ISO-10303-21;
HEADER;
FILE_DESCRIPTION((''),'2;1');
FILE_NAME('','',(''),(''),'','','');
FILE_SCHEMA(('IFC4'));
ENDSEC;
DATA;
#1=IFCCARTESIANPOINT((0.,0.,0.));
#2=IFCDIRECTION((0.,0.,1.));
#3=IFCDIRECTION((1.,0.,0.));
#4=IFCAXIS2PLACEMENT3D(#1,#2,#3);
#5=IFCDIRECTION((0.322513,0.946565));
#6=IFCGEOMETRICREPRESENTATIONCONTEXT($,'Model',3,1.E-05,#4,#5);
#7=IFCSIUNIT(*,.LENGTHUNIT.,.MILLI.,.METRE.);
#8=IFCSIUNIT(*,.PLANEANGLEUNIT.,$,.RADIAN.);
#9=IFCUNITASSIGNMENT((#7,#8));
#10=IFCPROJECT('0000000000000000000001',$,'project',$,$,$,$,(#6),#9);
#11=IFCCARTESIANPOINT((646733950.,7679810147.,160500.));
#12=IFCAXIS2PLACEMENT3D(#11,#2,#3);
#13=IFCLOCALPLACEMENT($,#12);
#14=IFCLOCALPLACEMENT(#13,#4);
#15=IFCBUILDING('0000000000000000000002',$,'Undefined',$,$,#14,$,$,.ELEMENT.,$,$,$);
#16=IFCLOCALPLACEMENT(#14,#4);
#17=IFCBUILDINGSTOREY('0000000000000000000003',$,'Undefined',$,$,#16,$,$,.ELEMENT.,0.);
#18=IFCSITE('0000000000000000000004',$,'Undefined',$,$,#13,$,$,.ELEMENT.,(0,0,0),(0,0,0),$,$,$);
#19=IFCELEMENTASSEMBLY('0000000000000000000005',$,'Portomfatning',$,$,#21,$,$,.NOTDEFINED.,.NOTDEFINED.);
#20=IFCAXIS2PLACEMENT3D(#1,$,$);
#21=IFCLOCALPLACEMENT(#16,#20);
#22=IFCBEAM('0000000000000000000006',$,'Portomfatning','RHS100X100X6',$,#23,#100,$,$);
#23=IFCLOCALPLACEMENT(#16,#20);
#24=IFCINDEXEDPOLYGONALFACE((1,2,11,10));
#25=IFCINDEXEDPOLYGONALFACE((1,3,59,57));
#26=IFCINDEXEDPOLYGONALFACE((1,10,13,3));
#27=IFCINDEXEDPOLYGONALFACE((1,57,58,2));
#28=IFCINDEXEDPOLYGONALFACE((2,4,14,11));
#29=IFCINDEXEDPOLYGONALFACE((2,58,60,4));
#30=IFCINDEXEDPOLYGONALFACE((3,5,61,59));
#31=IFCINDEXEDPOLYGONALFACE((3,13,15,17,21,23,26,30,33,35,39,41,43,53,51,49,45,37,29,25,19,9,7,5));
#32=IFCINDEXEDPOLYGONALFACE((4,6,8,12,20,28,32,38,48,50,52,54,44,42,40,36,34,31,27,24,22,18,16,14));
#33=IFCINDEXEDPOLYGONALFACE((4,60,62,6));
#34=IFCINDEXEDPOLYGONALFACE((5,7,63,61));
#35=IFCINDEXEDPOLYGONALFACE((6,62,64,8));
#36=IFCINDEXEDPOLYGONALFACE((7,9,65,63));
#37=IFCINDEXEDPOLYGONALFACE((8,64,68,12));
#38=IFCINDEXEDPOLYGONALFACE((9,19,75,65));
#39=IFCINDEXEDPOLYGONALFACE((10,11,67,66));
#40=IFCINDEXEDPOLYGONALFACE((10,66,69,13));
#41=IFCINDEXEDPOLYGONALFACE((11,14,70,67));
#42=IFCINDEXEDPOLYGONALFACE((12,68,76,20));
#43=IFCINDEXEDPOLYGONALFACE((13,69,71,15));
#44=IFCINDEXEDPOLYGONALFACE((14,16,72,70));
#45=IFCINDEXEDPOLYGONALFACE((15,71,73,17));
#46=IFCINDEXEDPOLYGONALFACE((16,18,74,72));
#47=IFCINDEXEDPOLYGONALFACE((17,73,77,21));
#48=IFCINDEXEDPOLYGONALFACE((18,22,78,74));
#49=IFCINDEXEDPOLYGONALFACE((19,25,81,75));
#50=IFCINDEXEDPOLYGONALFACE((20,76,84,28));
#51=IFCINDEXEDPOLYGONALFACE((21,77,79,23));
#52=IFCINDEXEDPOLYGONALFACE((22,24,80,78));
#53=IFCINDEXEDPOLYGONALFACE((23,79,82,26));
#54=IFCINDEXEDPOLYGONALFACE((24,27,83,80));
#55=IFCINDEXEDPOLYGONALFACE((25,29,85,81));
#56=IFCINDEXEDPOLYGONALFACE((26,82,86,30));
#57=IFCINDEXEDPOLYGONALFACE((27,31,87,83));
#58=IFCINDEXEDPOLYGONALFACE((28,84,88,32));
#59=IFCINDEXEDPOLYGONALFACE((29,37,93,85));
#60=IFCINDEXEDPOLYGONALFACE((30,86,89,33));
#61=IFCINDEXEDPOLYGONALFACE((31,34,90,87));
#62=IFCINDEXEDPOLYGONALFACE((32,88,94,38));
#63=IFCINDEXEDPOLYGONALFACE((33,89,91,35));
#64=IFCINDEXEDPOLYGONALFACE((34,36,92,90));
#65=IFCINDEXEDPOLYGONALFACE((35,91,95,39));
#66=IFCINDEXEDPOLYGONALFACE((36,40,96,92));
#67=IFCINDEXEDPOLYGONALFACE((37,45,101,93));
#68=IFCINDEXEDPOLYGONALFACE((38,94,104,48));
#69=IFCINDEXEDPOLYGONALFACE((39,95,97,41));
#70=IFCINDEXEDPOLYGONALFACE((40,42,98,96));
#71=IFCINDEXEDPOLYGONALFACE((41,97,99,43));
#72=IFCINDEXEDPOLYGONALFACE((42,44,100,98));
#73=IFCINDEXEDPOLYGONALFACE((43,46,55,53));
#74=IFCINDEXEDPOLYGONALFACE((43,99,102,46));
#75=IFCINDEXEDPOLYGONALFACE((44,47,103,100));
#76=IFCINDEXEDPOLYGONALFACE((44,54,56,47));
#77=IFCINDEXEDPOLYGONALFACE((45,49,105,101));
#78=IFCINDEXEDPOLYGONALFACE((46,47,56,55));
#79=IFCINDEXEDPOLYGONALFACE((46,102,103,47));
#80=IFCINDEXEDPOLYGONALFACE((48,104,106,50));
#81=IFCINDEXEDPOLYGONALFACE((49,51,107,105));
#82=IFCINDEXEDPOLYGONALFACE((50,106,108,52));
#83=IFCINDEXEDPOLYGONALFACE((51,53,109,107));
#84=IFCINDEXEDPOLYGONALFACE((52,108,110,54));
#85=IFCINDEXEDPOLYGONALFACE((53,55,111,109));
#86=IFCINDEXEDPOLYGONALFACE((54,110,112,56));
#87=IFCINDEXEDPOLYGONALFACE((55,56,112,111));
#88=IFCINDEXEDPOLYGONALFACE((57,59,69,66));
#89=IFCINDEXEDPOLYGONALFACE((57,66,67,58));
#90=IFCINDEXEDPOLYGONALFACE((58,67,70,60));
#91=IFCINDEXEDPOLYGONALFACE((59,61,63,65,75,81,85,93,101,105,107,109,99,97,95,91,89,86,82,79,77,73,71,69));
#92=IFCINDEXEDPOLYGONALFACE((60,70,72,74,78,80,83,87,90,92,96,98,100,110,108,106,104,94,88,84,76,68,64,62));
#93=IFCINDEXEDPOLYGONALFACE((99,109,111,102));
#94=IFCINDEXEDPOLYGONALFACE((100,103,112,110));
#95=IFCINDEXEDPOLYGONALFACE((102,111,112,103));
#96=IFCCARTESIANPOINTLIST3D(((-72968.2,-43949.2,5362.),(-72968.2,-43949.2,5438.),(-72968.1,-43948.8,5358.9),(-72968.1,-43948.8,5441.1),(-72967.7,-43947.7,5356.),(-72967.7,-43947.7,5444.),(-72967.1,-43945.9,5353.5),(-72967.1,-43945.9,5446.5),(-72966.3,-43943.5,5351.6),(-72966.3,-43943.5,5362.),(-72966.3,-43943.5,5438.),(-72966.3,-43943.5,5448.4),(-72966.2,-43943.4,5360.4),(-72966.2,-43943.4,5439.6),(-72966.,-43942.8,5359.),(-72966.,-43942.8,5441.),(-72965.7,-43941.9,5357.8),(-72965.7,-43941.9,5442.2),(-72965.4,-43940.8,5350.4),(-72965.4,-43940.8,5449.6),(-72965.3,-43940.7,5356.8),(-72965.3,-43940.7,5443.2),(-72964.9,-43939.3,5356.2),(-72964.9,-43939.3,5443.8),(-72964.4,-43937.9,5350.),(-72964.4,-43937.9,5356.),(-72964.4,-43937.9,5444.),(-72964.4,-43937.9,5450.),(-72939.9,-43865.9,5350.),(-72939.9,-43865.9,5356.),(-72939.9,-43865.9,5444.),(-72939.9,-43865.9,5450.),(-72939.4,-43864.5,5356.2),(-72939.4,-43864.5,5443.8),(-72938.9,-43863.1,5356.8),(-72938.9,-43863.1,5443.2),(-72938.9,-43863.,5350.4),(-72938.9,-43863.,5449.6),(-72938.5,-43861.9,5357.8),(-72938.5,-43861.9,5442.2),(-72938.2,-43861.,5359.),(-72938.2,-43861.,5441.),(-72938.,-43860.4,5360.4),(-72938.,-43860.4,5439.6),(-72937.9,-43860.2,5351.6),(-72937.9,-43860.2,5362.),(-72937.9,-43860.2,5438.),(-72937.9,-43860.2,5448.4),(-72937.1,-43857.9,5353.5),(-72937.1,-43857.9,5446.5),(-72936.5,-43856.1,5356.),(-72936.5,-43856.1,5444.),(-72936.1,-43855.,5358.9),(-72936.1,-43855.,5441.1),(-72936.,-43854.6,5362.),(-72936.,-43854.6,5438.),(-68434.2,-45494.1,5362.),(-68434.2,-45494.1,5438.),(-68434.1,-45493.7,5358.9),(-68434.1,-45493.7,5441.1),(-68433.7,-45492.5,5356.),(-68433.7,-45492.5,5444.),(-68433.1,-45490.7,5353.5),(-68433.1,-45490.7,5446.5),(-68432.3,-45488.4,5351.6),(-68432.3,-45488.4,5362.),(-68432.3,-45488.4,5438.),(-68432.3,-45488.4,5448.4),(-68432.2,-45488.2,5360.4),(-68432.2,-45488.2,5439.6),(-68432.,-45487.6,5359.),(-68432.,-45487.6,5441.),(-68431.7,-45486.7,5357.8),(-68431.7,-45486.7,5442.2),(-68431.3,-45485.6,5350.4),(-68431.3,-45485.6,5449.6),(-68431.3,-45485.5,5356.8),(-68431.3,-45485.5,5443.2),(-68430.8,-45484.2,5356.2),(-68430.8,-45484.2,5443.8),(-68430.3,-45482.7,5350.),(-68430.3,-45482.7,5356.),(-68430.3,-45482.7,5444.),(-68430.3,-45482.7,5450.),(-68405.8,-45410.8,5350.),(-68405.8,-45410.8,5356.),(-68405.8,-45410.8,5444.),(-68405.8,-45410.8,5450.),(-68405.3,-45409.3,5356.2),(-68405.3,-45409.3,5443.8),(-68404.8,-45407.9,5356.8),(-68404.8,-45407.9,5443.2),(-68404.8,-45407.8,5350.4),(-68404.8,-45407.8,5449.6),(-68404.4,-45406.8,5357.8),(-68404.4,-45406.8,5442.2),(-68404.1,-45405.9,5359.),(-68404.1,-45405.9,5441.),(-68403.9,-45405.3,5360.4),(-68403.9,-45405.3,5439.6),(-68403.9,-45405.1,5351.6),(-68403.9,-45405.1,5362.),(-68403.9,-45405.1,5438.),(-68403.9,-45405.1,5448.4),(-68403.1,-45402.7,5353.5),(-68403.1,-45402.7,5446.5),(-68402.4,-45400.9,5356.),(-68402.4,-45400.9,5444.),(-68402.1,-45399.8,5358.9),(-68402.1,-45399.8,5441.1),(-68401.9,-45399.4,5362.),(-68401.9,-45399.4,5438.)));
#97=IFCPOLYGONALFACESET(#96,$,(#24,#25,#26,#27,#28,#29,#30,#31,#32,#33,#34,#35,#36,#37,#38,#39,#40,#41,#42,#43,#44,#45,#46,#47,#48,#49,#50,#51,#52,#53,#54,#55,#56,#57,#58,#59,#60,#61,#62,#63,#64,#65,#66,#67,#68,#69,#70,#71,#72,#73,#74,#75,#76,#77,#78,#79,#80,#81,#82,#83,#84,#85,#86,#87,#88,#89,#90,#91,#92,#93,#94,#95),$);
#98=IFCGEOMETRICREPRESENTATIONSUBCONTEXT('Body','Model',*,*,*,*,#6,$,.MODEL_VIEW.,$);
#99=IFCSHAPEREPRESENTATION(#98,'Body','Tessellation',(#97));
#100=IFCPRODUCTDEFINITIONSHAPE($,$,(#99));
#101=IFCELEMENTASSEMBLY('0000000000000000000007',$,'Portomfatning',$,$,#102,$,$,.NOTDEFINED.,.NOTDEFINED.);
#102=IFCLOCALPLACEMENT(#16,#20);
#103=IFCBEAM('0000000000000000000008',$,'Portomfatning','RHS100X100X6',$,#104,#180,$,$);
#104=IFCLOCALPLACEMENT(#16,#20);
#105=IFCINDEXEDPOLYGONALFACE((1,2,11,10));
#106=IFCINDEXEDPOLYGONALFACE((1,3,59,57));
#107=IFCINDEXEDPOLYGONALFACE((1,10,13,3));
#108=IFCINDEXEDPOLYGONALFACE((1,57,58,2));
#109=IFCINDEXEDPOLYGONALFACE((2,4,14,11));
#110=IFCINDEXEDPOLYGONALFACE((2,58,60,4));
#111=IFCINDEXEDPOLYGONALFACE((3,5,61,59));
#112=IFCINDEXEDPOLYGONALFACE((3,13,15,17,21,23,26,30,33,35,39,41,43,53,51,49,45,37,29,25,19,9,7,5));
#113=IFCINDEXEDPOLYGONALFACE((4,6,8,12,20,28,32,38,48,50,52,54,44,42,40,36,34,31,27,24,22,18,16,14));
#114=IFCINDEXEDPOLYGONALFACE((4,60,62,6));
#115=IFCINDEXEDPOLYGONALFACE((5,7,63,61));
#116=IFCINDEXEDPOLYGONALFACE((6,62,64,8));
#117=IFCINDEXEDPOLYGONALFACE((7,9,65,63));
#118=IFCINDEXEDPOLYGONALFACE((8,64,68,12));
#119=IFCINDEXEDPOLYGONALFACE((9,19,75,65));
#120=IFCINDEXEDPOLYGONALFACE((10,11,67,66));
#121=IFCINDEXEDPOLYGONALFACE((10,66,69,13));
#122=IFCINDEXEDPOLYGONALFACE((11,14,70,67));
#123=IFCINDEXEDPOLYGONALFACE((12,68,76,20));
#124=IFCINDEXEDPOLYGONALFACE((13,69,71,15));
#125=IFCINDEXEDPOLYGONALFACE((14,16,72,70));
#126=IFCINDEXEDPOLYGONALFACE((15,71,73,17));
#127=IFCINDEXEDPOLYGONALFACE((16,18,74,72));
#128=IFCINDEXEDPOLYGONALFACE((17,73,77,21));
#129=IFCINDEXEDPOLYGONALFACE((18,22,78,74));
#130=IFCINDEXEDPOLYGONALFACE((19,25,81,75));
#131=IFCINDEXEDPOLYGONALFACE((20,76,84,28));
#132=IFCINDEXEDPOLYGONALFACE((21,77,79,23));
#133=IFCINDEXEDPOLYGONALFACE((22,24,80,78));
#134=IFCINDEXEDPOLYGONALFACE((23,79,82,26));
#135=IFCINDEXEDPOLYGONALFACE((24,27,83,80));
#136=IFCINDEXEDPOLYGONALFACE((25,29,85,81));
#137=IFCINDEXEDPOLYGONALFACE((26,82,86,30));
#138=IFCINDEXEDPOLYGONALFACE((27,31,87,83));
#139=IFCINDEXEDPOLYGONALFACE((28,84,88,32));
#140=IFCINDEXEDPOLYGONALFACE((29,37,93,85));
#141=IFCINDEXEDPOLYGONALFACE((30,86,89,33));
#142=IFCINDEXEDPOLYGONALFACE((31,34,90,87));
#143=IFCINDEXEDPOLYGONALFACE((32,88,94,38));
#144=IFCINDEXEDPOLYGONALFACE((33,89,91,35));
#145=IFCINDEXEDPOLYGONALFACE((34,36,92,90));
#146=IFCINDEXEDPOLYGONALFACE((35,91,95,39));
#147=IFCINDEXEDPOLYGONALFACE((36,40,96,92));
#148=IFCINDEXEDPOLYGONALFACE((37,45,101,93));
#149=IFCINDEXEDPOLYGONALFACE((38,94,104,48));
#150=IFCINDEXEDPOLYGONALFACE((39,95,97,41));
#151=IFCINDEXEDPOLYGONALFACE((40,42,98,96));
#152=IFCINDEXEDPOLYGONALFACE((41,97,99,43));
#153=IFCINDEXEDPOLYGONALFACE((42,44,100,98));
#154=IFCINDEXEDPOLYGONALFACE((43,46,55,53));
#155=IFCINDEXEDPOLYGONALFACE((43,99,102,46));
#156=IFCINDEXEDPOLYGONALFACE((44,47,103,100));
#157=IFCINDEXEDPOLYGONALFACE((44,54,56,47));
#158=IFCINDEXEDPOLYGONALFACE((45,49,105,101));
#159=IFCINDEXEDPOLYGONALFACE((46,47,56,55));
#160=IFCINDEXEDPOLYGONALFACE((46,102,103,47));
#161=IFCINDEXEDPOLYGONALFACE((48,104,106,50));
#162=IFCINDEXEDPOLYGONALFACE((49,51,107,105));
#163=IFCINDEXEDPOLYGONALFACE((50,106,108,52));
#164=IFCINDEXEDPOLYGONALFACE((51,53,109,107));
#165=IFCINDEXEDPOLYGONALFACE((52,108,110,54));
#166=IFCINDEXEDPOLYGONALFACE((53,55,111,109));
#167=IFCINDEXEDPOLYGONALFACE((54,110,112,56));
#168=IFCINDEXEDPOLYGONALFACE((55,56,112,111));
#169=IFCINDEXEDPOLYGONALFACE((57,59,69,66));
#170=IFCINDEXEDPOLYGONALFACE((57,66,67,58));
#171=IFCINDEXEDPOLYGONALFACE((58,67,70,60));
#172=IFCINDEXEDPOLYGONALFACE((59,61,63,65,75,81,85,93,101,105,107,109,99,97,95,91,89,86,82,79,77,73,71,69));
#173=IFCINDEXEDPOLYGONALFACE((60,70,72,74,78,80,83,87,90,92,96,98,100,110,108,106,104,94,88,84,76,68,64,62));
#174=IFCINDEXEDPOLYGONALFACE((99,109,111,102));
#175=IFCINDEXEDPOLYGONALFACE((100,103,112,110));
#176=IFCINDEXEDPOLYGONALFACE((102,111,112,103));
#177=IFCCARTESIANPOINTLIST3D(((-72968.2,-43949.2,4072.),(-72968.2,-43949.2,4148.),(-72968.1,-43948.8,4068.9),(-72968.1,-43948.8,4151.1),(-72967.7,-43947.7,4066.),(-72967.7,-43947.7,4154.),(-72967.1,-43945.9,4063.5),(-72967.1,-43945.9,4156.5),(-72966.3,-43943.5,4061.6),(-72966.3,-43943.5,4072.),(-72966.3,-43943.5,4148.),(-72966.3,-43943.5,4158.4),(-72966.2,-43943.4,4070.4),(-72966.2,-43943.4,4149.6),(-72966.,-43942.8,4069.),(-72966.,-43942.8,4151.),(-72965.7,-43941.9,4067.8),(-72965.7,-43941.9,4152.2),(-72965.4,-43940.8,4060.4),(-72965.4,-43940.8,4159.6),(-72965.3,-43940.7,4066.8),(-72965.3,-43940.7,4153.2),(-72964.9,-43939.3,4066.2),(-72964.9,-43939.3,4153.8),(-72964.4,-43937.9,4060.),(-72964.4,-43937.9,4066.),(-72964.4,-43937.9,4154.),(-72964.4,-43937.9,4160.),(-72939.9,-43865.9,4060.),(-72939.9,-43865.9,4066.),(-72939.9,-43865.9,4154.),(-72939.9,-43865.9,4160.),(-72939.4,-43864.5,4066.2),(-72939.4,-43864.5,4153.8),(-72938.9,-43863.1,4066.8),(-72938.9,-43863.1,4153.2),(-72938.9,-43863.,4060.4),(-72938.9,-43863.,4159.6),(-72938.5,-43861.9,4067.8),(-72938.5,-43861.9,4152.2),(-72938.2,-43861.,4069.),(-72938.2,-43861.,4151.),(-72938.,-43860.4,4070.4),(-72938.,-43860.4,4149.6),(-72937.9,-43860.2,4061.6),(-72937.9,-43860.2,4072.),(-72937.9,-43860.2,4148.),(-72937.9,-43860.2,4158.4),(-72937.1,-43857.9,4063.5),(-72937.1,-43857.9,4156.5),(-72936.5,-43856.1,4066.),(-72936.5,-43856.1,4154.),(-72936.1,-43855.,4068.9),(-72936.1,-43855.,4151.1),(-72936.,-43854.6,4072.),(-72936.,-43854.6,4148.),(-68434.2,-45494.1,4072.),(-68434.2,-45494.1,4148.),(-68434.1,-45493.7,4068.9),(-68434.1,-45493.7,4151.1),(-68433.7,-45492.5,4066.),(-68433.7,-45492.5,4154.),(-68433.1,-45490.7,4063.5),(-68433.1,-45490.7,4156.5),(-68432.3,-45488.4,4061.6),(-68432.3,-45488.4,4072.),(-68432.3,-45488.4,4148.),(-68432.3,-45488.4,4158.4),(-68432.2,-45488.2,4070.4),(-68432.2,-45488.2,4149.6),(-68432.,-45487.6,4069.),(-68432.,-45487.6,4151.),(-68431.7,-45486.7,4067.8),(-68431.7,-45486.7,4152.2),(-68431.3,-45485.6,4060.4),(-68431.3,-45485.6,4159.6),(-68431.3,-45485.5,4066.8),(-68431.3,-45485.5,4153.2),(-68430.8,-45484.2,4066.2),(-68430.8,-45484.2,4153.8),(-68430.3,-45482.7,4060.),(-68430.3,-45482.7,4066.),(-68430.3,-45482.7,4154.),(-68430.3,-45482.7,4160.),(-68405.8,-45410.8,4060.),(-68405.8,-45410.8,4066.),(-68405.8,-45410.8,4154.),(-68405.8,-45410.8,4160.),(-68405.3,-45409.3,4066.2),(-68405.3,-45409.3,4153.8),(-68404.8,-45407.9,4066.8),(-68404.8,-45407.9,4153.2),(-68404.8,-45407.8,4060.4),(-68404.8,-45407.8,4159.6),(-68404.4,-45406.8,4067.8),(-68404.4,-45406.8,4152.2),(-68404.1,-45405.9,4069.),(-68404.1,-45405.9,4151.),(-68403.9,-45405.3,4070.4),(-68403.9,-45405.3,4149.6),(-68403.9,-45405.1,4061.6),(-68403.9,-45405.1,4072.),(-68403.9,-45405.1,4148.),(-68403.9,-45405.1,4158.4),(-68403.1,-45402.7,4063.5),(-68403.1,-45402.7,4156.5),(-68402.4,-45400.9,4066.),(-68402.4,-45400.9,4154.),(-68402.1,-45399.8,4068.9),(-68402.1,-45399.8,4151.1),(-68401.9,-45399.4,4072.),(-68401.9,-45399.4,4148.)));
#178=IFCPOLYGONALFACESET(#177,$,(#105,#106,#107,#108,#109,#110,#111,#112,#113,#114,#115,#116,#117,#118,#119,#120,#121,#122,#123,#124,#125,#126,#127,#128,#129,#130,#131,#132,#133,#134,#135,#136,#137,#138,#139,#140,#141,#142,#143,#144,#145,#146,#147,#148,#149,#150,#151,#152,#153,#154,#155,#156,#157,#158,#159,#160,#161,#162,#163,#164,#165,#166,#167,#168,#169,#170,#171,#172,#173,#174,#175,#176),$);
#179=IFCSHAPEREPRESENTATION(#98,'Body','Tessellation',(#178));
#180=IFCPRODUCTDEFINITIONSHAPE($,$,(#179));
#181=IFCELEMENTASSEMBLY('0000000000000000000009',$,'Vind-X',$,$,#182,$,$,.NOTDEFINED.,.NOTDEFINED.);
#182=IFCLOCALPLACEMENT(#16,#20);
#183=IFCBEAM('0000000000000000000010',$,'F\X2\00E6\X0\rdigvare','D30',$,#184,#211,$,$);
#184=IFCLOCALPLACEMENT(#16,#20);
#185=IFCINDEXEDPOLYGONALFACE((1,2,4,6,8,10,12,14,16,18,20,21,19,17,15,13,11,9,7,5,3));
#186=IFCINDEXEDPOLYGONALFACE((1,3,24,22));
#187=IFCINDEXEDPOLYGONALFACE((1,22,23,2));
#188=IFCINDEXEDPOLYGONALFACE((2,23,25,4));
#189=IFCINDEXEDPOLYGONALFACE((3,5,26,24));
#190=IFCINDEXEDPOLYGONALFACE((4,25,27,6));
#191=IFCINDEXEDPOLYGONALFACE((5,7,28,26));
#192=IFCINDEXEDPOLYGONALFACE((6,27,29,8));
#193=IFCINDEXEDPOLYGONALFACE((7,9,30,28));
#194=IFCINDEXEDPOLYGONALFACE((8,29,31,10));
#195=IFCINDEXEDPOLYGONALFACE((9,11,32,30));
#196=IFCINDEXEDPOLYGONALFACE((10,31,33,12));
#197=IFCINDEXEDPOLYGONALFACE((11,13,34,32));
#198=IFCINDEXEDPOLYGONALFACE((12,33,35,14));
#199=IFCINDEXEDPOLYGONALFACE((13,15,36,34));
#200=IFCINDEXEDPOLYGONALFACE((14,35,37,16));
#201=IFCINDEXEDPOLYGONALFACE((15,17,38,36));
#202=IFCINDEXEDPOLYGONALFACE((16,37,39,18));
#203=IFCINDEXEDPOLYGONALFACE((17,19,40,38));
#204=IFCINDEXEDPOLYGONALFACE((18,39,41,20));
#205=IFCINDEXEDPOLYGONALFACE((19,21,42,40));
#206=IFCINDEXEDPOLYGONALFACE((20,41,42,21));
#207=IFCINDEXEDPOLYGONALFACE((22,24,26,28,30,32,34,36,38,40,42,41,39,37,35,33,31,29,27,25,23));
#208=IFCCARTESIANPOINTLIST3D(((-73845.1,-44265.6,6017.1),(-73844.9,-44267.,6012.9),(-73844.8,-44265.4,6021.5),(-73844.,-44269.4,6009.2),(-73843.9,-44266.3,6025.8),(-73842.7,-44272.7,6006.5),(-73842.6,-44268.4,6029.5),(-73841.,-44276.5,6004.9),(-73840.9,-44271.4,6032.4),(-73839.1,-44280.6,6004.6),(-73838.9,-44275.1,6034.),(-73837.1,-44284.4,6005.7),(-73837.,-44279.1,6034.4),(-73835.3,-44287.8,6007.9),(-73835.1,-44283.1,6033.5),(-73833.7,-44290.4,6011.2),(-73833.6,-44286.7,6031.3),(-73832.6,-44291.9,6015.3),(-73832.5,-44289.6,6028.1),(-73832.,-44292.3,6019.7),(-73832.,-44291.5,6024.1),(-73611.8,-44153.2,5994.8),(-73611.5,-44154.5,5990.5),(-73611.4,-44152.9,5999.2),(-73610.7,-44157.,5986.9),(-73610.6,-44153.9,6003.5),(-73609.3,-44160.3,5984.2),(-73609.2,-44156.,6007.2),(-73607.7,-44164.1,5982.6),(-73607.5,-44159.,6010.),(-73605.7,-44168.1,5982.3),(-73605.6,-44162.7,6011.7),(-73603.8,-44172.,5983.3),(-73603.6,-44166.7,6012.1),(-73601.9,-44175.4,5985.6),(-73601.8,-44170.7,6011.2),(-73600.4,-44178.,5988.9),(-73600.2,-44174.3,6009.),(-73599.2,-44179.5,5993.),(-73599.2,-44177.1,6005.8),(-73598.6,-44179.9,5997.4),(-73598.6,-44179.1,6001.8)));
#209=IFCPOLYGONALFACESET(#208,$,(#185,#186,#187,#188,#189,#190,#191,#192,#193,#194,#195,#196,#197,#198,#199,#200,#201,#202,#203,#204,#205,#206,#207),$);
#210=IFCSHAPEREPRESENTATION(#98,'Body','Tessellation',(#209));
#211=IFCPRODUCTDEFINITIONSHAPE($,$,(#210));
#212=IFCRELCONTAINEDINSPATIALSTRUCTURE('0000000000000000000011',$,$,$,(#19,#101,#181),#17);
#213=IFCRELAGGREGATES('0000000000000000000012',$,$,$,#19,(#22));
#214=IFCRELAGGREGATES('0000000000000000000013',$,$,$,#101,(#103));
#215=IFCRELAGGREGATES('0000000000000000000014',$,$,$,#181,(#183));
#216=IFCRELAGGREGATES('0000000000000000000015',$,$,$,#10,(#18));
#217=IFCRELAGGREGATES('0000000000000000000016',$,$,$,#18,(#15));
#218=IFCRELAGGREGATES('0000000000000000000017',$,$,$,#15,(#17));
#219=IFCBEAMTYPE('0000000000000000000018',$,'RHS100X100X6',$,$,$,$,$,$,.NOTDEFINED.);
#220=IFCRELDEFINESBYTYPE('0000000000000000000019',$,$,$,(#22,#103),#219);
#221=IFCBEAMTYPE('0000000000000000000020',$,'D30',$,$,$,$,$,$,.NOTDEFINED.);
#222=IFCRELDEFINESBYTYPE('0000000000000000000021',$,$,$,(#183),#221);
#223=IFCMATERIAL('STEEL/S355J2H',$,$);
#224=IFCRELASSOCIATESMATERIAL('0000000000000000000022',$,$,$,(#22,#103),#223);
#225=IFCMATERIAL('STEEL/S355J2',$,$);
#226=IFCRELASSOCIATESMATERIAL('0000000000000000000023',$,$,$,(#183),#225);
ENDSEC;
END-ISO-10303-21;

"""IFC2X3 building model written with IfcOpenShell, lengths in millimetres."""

from ifc_helpers import new_model, si_unit, direction, frame, origin_with_axes, origin_2d_with_axis, place, context, subcontext, project, spatial, hollow_rectangle, circle, extrude, clip, halfspace, material, type_object, element, aggregate, save


model = new_model("IFC2X3")

# Units and contexts
model_context = context("Model", 3, precision=1e-05, world=origin_with_axes(), true_north=direction((0.322513, 0.946565)))
body_context = subcontext(model_context, "Body", "Model", "MODEL_VIEW")
ifc_project = project(units=[si_unit("LENGTHUNIT", "METRE", prefix="MILLI"), si_unit("PLANEANGLEUNIT", "RADIAN")], contexts=[model_context])

# Site, building, storey
site_placement = place(None, frame((646733950.0, 7679810147.0, 160500.0), z_axis=(0.0, 0.0, 1.0), x_axis=(1.0, 0.0, 0.0)))
site = spatial("IfcSite", under=ifc_project, at=site_placement, Name="Undefined", CompositionType="ELEMENT", RefLatitude=(0, 0, 0), RefLongitude=(0, 0, 0))
building_placement = place(site_placement, origin_with_axes())
building = spatial("IfcBuilding", under=site, at=building_placement, Name="Undefined", CompositionType="ELEMENT")
storey_placement = place(building_placement, origin_with_axes())
storey = spatial("IfcBuildingStorey", under=building, at=storey_placement, Name="Undefined", CompositionType="ELEMENT", Elevation=0.0)

# Element assemblies, beams
assembly_1_placement = place(storey_placement, origin_with_axes())
assembly_1 = element("IfcElementAssembly", 1, at=assembly_1_placement, inside=storey, Name="Portomfatning", AssemblyPlace="NOTDEFINED", PredefinedType="NOTDEFINED")
ifc_material_1 = material(Name="STEEL/S355J2H")
beam_type_1 = type_object("IfcBeamType", Name="RHS100X100X6", PredefinedType="NOTDEFINED")
beam_1_placement = place(assembly_1_placement, frame((-72965.8, -43897.2, 5400.0), z_axis=(0.322513, 0.946565, 0.0), x_axis=(0.946565, -0.322513, 0.0)))
beam_1 = element("IfcBeam", 2, at=beam_1_placement, type_object=beam_type_1, material=ifc_material_1, Name="Portomfatning", Description="RHS100X100X6", context=body_context, shape_type="Clipping", body=[
    clip(clip(extrude(hollow_rectangle(XDim=100.0, YDim=100.0, WallThickness=6.0, InnerFilletRadius=6.0, OuterFilletRadius=12.0, at=origin_2d_with_axis()), frame((4866.1, 0.0, 0.0), z_axis=(-1.0, 0.0, 0.0), x_axis=(0.0, -1.0, 0.0)), (0.0, 0.0, 1.0), 4913.4), halfspace(frame((4804.5, -50.0, -50.0), z_axis=(-1.0, 0.0, 0.000185), x_axis=(0.0, 1.0, 0.0)), True)), halfspace(frame((14.5, 50.0, -50.0), z_axis=(1.0, 0.0, 0.000185), x_axis=(0.0, -1.0, 0.0)), True)),
])
aggregate(assembly_1, [beam_1])
assembly_2_placement = place(storey_placement, origin_with_axes())
assembly_2 = element("IfcElementAssembly", 3, at=assembly_2_placement, inside=storey, Name="Portomfatning", AssemblyPlace="NOTDEFINED", PredefinedType="NOTDEFINED")
beam_2_placement = place(assembly_2_placement, frame((-72965.8, -43897.2, 4110.0), z_axis=(0.322513, 0.946565, 0.0), x_axis=(0.946565, -0.322513, 0.0)))
beam_2 = element("IfcBeam", 4, at=beam_2_placement, type_object=beam_type_1, material=ifc_material_1, Name="Portomfatning", Description="RHS100X100X6", context=body_context, shape_type="Clipping", body=[
    clip(clip(extrude(hollow_rectangle(XDim=100.0, YDim=100.0, WallThickness=6.0, InnerFilletRadius=6.0, OuterFilletRadius=12.0, at=origin_2d_with_axis()), frame((4866.1, 0.0, 0.0), z_axis=(-1.0, 0.0, 0.0), x_axis=(0.0, -1.0, 0.0)), (0.0, 0.0, 1.0), 4913.4), halfspace(frame((4804.5, -50.0, -50.0), z_axis=(-1.0, 0.0, 0.000185), x_axis=(0.0, 1.0, 0.0)), True)), halfspace(frame((14.5, 50.0, -50.0), z_axis=(1.0, 0.0, 0.000185), x_axis=(0.0, -1.0, 0.0)), True)),
])

# Element assembly, beam
assembly_3_placement = place(storey_placement, origin_with_axes())
assembly_3 = element("IfcElementAssembly", 5, at=assembly_3_placement, inside=storey, Name="Vind-X", AssemblyPlace="NOTDEFINED", PredefinedType="NOTDEFINED")
ifc_material_2 = material(Name="STEEL/S355J2")
beam_type_2 = type_object("IfcBeamType", Name="D30", PredefinedType="NOTDEFINED")
beam_3_placement = place(assembly_3_placement, frame((-73605.2, -44166.4, 5997.2), z_axis=(-0.439079, 0.89427, -0.086548), x_axis=(-0.897589, -0.432404, 0.0858)))
beam_3 = element("IfcBeam", 6, at=beam_3_placement, type_object=beam_type_2, material=ifc_material_2, Name="Færdigvare", Description="D30", context=body_context, shape_type="SweptSolid", body=[
    extrude(circle(Radius=15.0, at=origin_2d_with_axis()), frame((260.0, 0.0, 0.0), z_axis=(-1.0, 0.0, 0.0), x_axis=(0.0, -1.0, 0.0)), (0.0, 0.0, 1.0), 260.0),
])

aggregate(assembly_2, [beam_2])

aggregate(assembly_3, [beam_3])

save(model, "model.ifc")
